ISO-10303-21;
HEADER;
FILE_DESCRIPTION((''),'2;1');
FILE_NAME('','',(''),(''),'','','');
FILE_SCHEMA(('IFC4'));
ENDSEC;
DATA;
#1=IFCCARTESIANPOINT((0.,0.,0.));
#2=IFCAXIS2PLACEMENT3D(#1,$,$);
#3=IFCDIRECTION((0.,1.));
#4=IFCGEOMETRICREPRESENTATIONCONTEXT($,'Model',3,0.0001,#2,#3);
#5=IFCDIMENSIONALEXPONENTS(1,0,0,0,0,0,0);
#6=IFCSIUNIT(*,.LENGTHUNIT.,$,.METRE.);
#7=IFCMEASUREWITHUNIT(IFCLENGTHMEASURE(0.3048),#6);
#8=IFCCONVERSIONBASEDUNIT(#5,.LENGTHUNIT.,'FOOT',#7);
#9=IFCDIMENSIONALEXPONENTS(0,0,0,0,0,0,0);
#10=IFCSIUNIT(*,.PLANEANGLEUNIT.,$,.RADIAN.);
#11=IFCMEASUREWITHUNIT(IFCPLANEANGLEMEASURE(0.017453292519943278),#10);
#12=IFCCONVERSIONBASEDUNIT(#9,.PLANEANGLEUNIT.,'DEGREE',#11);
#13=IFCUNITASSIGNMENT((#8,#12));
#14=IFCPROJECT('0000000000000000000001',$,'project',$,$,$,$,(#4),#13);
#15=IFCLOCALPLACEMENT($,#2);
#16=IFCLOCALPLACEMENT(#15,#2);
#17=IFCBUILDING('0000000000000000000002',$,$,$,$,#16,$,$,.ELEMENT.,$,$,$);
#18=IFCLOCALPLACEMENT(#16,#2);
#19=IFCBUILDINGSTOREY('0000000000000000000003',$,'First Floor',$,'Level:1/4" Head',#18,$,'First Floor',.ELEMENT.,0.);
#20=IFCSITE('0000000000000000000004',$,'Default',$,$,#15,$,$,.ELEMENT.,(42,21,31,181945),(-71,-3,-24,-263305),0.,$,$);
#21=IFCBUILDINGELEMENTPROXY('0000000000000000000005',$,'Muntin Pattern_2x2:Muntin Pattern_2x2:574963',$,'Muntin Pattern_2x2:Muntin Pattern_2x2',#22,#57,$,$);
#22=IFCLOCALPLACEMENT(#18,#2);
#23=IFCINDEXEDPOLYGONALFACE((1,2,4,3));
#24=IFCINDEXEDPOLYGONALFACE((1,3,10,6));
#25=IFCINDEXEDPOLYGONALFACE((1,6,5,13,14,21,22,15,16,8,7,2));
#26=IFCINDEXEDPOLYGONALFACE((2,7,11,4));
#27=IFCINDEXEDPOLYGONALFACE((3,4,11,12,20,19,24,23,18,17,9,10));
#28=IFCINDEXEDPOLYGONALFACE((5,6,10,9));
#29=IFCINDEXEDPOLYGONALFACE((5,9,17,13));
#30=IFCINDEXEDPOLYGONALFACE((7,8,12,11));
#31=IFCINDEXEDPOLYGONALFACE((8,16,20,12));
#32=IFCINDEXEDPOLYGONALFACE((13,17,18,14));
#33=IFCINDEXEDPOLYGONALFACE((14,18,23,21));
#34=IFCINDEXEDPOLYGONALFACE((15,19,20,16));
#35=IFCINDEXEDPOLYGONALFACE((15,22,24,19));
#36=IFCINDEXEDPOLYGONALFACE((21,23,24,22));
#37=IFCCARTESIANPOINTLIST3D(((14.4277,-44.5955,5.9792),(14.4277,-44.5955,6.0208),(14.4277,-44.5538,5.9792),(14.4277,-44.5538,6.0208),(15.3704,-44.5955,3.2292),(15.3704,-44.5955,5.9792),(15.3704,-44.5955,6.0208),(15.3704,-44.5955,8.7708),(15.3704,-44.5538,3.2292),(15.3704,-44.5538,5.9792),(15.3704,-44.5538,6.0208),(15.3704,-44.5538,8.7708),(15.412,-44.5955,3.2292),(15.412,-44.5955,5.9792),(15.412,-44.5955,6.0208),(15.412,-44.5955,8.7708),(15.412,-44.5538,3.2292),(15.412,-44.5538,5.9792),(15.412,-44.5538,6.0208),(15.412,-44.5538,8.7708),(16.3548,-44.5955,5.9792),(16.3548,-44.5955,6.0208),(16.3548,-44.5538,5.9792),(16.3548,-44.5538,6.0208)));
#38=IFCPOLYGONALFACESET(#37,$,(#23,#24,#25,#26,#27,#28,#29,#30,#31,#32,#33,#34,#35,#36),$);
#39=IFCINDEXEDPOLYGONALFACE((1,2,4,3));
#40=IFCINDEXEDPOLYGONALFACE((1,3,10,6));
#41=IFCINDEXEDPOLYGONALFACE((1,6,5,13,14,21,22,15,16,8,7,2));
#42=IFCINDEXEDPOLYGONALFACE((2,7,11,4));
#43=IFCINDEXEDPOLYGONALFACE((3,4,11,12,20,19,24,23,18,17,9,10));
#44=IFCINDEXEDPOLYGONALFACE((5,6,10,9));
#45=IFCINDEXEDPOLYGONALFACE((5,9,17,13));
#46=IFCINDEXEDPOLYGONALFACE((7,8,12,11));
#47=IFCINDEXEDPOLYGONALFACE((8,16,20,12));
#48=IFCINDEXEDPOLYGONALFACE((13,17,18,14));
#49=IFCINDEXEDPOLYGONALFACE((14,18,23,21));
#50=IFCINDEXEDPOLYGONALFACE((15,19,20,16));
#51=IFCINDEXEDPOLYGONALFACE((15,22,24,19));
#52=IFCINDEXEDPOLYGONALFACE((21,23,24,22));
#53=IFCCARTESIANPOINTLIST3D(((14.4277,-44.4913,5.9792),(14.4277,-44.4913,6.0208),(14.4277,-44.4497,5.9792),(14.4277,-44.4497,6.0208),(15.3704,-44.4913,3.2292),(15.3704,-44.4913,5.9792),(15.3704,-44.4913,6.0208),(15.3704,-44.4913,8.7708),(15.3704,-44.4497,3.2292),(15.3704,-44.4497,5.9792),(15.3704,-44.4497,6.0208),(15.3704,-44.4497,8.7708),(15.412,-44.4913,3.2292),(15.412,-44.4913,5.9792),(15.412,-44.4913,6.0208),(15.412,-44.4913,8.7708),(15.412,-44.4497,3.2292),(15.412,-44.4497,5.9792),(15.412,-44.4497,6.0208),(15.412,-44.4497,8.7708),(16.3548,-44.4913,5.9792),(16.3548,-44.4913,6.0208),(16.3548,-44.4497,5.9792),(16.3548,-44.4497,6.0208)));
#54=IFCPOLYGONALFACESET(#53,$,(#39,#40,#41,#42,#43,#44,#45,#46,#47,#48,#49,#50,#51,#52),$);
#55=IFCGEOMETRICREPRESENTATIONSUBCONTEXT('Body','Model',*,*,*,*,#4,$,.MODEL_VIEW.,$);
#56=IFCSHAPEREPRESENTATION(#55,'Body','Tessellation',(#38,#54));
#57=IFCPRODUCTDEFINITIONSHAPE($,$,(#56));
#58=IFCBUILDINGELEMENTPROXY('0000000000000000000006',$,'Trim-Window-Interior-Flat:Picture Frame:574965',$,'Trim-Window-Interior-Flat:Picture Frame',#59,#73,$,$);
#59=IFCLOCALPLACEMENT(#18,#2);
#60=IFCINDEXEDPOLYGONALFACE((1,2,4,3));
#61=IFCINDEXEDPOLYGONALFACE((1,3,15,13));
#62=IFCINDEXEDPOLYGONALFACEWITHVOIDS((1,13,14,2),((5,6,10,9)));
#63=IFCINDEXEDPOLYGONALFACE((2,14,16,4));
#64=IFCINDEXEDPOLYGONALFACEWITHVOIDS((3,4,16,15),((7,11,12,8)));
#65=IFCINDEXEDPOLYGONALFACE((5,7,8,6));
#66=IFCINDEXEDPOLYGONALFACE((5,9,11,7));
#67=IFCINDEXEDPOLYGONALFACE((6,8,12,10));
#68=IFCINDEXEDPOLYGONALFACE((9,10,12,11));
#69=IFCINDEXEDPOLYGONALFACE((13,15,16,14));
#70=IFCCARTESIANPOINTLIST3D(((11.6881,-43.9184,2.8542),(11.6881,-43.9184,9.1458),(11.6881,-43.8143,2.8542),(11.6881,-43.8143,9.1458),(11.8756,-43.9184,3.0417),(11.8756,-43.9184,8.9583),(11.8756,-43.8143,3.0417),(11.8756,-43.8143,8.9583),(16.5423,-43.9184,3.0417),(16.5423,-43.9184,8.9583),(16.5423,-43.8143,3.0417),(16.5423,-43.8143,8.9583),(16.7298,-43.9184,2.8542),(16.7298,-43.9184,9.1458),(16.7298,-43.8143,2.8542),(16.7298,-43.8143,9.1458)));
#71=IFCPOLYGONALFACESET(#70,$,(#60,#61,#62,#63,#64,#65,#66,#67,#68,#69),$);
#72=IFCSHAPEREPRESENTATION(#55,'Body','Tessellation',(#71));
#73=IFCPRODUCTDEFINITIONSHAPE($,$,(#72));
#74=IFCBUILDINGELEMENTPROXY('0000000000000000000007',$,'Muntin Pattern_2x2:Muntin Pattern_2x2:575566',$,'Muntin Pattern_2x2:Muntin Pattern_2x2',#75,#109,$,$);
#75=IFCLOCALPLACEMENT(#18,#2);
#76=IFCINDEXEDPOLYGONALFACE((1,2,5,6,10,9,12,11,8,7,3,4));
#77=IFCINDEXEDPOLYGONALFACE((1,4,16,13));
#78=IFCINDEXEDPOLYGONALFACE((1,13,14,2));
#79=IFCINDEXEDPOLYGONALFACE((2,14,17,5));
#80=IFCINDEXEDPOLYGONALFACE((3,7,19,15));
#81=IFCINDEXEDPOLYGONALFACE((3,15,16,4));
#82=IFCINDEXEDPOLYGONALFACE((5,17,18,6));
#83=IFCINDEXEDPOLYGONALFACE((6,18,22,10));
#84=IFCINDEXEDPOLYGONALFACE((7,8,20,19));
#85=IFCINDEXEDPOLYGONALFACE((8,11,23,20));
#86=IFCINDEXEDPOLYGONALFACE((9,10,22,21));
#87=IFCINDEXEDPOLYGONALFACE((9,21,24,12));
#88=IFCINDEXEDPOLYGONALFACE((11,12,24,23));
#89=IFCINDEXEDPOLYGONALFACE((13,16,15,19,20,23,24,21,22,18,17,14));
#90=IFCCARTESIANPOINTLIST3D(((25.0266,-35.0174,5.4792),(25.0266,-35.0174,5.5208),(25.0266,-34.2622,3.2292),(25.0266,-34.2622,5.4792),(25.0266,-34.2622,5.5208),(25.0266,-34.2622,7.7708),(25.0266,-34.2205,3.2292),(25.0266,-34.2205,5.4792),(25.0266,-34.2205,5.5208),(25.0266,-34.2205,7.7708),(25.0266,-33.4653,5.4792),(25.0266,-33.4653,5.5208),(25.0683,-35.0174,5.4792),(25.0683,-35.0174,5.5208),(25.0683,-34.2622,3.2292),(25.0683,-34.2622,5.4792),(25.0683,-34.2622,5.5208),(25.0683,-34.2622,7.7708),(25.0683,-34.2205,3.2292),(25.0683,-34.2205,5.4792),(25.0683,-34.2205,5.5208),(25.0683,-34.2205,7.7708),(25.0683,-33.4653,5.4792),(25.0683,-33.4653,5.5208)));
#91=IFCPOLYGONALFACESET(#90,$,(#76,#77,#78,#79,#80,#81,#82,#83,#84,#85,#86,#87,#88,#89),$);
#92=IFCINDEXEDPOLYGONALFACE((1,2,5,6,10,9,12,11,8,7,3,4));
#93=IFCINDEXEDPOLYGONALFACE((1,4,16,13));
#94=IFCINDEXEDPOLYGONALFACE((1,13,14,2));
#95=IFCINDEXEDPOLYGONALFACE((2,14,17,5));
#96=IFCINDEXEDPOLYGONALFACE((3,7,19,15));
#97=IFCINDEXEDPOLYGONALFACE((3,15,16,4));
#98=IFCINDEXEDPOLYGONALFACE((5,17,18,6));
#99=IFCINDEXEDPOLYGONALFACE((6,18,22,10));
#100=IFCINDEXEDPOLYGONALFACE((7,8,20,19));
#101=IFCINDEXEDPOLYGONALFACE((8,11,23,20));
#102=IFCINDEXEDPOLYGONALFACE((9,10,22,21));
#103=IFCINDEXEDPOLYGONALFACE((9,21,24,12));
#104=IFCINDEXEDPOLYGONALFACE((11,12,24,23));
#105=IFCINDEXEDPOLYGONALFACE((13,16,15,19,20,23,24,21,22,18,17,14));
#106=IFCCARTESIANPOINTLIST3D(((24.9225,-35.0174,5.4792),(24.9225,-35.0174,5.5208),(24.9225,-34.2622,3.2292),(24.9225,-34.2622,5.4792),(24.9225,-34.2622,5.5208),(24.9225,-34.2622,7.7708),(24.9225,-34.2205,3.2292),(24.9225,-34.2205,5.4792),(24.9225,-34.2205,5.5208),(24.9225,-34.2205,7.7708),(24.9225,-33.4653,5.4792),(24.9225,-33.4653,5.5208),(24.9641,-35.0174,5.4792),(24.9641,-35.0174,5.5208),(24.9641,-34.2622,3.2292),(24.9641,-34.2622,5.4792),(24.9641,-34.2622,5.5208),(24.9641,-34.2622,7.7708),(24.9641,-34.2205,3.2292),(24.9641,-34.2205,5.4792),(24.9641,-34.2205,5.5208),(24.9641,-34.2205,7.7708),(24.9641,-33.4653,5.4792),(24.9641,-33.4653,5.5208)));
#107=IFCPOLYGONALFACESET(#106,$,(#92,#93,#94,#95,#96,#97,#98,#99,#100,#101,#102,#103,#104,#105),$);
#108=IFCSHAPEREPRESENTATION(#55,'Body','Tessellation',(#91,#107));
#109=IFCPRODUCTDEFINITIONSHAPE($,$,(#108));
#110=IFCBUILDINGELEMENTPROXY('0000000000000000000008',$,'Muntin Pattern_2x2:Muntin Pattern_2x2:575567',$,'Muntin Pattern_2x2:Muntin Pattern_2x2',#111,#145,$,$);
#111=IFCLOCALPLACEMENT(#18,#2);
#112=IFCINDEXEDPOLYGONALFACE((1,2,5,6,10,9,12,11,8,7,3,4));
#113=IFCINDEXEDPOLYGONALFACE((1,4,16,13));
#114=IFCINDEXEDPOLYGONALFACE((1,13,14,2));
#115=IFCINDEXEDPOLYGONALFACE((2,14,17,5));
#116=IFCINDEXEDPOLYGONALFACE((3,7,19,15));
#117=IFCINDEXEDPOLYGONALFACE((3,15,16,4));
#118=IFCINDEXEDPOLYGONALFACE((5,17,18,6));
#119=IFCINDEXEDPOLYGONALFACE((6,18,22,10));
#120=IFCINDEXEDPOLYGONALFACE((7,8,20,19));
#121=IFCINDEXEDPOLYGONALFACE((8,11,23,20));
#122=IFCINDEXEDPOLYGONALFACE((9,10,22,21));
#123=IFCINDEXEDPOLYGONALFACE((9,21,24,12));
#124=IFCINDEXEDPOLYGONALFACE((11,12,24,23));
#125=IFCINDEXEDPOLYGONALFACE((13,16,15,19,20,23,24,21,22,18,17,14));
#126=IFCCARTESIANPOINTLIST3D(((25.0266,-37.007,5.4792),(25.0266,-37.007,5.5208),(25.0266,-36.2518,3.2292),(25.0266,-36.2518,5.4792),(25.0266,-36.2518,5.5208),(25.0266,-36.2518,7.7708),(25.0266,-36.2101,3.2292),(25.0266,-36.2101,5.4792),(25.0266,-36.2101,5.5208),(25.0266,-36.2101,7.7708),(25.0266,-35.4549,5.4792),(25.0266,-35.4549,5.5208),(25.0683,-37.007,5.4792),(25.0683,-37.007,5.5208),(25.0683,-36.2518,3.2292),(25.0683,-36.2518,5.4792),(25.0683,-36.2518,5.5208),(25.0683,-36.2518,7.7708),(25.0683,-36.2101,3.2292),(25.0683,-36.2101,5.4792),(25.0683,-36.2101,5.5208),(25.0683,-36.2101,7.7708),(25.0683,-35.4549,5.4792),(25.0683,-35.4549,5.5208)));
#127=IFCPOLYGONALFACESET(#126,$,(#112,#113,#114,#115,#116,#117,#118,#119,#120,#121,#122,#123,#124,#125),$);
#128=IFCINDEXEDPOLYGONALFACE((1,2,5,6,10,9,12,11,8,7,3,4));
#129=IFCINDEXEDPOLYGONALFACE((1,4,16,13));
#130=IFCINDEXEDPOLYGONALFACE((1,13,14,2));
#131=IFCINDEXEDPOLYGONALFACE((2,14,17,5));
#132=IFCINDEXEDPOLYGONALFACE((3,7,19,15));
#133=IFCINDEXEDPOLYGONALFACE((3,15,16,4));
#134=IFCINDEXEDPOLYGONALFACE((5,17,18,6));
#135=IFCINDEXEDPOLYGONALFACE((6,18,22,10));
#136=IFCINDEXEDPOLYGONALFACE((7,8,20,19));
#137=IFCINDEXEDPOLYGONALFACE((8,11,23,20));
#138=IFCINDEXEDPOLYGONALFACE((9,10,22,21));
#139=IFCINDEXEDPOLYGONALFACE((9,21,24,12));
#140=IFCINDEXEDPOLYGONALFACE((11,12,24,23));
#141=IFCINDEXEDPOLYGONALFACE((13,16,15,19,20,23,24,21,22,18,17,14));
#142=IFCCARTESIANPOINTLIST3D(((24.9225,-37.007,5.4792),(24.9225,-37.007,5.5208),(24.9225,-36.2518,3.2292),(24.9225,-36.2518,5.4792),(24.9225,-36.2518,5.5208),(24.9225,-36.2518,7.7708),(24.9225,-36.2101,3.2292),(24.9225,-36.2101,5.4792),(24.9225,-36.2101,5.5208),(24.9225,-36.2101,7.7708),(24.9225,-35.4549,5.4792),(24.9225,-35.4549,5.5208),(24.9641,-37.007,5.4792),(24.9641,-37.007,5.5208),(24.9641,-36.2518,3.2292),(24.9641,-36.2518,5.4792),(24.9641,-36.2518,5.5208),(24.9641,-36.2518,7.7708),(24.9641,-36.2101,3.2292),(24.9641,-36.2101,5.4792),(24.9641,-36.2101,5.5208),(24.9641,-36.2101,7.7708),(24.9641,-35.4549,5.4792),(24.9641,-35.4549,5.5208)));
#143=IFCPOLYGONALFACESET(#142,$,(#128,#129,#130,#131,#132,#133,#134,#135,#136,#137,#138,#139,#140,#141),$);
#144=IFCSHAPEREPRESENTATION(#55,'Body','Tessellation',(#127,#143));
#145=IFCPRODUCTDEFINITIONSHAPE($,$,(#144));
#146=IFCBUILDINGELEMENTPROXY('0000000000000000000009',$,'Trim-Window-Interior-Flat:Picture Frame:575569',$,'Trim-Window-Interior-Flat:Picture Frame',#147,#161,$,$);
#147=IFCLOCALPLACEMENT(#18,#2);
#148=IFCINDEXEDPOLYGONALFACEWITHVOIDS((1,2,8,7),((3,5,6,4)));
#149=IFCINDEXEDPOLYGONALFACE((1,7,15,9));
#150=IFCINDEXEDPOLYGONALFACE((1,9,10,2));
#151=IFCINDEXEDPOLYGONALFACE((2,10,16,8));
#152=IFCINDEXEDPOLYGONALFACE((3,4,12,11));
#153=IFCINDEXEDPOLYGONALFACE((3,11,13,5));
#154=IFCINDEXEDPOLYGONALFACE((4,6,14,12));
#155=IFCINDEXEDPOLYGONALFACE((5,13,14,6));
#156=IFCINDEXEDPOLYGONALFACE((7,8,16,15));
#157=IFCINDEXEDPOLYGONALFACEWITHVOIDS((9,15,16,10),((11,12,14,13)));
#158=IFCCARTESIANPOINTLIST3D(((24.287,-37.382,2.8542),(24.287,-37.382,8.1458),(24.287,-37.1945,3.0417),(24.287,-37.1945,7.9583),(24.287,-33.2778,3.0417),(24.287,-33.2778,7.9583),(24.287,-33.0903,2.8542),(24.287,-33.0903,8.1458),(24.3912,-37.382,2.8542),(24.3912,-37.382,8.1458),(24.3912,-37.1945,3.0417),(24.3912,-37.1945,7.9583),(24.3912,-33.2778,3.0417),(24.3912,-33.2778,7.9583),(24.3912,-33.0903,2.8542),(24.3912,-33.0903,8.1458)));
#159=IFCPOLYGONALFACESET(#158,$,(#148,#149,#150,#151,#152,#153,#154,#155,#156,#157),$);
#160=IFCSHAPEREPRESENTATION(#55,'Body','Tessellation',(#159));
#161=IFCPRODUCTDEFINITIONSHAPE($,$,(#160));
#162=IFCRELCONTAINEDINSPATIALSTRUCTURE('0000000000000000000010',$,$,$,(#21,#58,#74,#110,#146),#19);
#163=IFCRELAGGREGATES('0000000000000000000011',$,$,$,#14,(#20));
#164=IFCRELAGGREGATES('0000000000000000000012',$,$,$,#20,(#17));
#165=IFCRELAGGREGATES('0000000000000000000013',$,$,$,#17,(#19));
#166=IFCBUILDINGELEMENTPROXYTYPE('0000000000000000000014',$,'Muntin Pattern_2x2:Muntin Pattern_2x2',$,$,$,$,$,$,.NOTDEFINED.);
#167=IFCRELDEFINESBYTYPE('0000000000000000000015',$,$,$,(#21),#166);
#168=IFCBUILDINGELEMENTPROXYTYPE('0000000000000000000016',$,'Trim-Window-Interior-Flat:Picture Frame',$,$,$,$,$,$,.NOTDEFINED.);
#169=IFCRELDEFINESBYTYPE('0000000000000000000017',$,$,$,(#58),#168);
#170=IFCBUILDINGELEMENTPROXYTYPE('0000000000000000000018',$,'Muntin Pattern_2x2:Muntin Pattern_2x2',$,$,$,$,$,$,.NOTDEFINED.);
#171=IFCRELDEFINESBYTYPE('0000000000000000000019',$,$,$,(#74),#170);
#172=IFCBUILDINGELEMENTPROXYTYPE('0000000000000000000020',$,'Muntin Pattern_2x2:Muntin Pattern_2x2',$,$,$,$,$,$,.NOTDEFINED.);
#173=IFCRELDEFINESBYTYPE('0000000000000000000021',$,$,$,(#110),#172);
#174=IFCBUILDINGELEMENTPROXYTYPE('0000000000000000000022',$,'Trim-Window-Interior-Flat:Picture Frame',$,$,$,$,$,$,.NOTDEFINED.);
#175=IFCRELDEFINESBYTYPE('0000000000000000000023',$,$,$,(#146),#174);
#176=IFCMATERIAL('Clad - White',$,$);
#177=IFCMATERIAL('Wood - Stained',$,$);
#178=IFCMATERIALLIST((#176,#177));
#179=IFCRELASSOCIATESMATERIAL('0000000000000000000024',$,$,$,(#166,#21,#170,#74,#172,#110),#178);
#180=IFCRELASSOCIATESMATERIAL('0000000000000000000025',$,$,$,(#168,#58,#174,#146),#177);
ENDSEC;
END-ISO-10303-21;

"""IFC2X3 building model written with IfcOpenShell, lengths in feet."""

from ifc_helpers import new_model, entity, si_unit, converted_unit, direction, frame, origin, place, context, subcontext, project, spatial, polyline, outline, extrude, source, transform, mapped, material, material_list, type_object, type_shapes, element, save


model = new_model("IFC2X3")

# Units and contexts
model_context = context("Model", 3, precision=0.0001, world=origin(), true_north=direction((0.0, 1.0)))
body_context = subcontext(model_context, "Body", "Model", "MODEL_VIEW")
ifc_project = project(units=[converted_unit("LENGTHUNIT", "FOOT", entity("IfcLengthMeasure", 0.3048), si_unit("LENGTHUNIT", "METRE"), dimensions=[1, 0, 0, 0, 0, 0, 0]), converted_unit("PLANEANGLEUNIT", "DEGREE", entity("IfcPlaneAngleMeasure", 0.017453292519943278), si_unit("PLANEANGLEUNIT", "RADIAN"), dimensions=[0, 0, 0, 0, 0, 0, 0])], contexts=[model_context])

# Site, building, storey
site_placement = place(None, origin())
site = spatial("IfcSite", under=ifc_project, at=site_placement, Name="Default", CompositionType="ELEMENT", RefLatitude=(42, 21, 31, 181945), RefLongitude=(-71, -3, -24, -263305), RefElevation=0.0)
building_placement = place(site_placement, origin())
building = spatial("IfcBuilding", under=site, at=building_placement, CompositionType="ELEMENT")
storey_placement = place(building_placement, origin())
storey = spatial("IfcBuildingStorey", under=building, at=storey_placement, Name="First Floor", ObjectType="Level:1/4\" Head", LongName="First Floor", CompositionType="ELEMENT", Elevation=0.0)

# Building element proxies
ifc_material_1 = material(Name="Clad - White")
ifc_material_2 = material(Name="Wood - Stained")
ifc_material_list_1 = material_list([ifc_material_1, ifc_material_2])
building_element_proxy_type_1 = type_object("IfcBuildingElementProxyType", Name="Muntin Pattern_2x2:Muntin Pattern_2x2", PredefinedType="NOTDEFINED", material=ifc_material_list_1)
shared_shape_1 = source(origin(), body_context, "Body", "SweptSolid", [
    extrude(outline(polyline([(0.0208, -0.0208), (2.7708, -0.0208), (2.7708, 0.0208), (0.0208, 0.0208), (0.0208, 0.9635), (-0.0208, 0.9635), (-0.0208, 0.0208), (-2.7708, 0.0208), (-2.7708, -0.0208), (-0.0208, -0.0208), (-0.0208, -0.9635), (0.0208, -0.9635), (0.0208, -0.0208)])), frame((0.0, 0.0313, 2.7708), z_axis=(0.0, 1.0, 0.0), x_axis=(0.0, 0.0, 1.0)), (0.0, 0.0, 1.0), 0.0417),
    extrude(outline(polyline([(0.0208, -0.0208), (2.7708, -0.0208), (2.7708, 0.0208), (0.0208, 0.0208), (0.0208, 0.9635), (-0.0208, 0.9635), (-0.0208, 0.0208), (-2.7708, 0.0208), (-2.7708, -0.0208), (-0.0208, -0.0208), (-0.0208, -0.9635), (0.0208, -0.9635), (0.0208, -0.0208)])), frame((0.0, -0.0729, 2.7708), z_axis=(0.0, 1.0, 0.0), x_axis=(0.0, 0.0, 1.0)), (0.0, 0.0, 1.0), 0.0417),
])
type_shapes(building_element_proxy_type_1, [shared_shape_1])
proxy_1_placement = place(storey_placement, frame((15.3912, -44.5226, 3.2292), z_axis=(0.0, 0.0, 1.0), x_axis=(-1.0, 0.0, 0.0)))
element("IfcBuildingElementProxy", 1, at=proxy_1_placement, inside=storey, type_object=building_element_proxy_type_1, material=ifc_material_list_1, Name="Muntin Pattern_2x2:Muntin Pattern_2x2:574963", ObjectType="Muntin Pattern_2x2:Muntin Pattern_2x2", context=body_context, shape_type="MappedRepresentation", body=[
    mapped(shared_shape_1, transform((0.0, 0.0, 0.0), scale=1.0)),
])
building_element_proxy_type_2 = type_object("IfcBuildingElementProxyType", Name="Trim-Window-Interior-Flat:Picture Frame", PredefinedType="NOTDEFINED", material=ifc_material_2)
shared_shape_2 = source(origin(), body_context, "Body", "SweptSolid", [
    extrude(outline(polyline([(-3.1458, -2.5208), (3.1458, -2.5208), (3.1458, 2.5208), (-3.1458, 2.5208), (-3.1458, -2.5208)]), holes=[polyline([(-2.9583, -2.3333), (-2.9583, 2.3333), (2.9583, 2.3333), (2.9583, -2.3333), (-2.9583, -2.3333)])]), frame((0.0, 3.0, 0.0), z_axis=(0.0, 0.0, 1.0), x_axis=(0.0, 1.0, 0.0)), (0.0, 0.0, 1.0), 0.1042),
])
type_shapes(building_element_proxy_type_2, [shared_shape_2])
proxy_2_placement = place(storey_placement, frame((14.2089, -43.9184, 9.0), z_axis=(0.0, 1.0, 0.0), x_axis=(1.0, 0.0, 0.0)))
element("IfcBuildingElementProxy", 2, at=proxy_2_placement, inside=storey, type_object=building_element_proxy_type_2, material=ifc_material_2, Name="Trim-Window-Interior-Flat:Picture Frame:574965", ObjectType="Trim-Window-Interior-Flat:Picture Frame", context=body_context, shape_type="MappedRepresentation", body=[
    mapped(shared_shape_2, transform((0.0, 0.0, 0.0), scale=1.0)),
])
building_element_proxy_type_3 = type_object("IfcBuildingElementProxyType", Name="Muntin Pattern_2x2:Muntin Pattern_2x2", PredefinedType="NOTDEFINED", material=ifc_material_list_1)
shared_shape_3 = source(origin(), body_context, "Body", "SweptSolid", [
    extrude(outline(polyline([(0.0208, -0.0208), (2.2708, -0.0208), (2.2708, 0.0208), (0.0208, 0.0208), (0.0208, 0.776), (-0.0208, 0.776), (-0.0208, 0.0208), (-2.2708, 0.0208), (-2.2708, -0.0208), (-0.0208, -0.0208), (-0.0208, -0.776), (0.0208, -0.776), (0.0208, -0.0208)])), frame((0.0, 0.0313, 2.2708), z_axis=(0.0, 1.0, 0.0), x_axis=(0.0, 0.0, 1.0)), (0.0, 0.0, 1.0), 0.0417),
    extrude(outline(polyline([(0.0208, -0.0208), (2.2708, -0.0208), (2.2708, 0.0208), (0.0208, 0.0208), (0.0208, 0.776), (-0.0208, 0.776), (-0.0208, 0.0208), (-2.2708, 0.0208), (-2.2708, -0.0208), (-0.0208, -0.0208), (-0.0208, -0.776), (0.0208, -0.776), (0.0208, -0.0208)])), frame((0.0, -0.0729, 2.2708), z_axis=(0.0, 1.0, 0.0), x_axis=(0.0, 0.0, 1.0)), (0.0, 0.0, 1.0), 0.0417),
])
type_shapes(building_element_proxy_type_3, [shared_shape_3])
proxy_3_placement = place(storey_placement, frame((24.9954, -34.2413, 3.2292), z_axis=(0.0, 0.0, 1.0), x_axis=(0.0, -1.0, 0.0)))
element("IfcBuildingElementProxy", 3, at=proxy_3_placement, inside=storey, type_object=building_element_proxy_type_3, material=ifc_material_list_1, Name="Muntin Pattern_2x2:Muntin Pattern_2x2:575566", ObjectType="Muntin Pattern_2x2:Muntin Pattern_2x2", context=body_context, shape_type="MappedRepresentation", body=[
    mapped(shared_shape_3, transform((0.0, 0.0, 0.0), scale=1.0)),
])
building_element_proxy_type_4 = type_object("IfcBuildingElementProxyType", Name="Muntin Pattern_2x2:Muntin Pattern_2x2", PredefinedType="NOTDEFINED", material=ifc_material_list_1)
shared_shape_4 = source(origin(), body_context, "Body", "SweptSolid", [
    extrude(outline(polyline([(0.0208, -0.0208), (2.2708, -0.0208), (2.2708, 0.0208), (0.0208, 0.0208), (0.0208, 0.776), (-0.0208, 0.776), (-0.0208, 0.0208), (-2.2708, 0.0208), (-2.2708, -0.0208), (-0.0208, -0.0208), (-0.0208, -0.776), (0.0208, -0.776), (0.0208, -0.0208)])), frame((0.0, -0.0729, 2.2708), z_axis=(0.0, 1.0, 0.0), x_axis=(0.0, 0.0, 1.0)), (0.0, 0.0, 1.0), 0.0417),
    extrude(outline(polyline([(0.0208, -0.0208), (2.2708, -0.0208), (2.2708, 0.0208), (0.0208, 0.0208), (0.0208, 0.776), (-0.0208, 0.776), (-0.0208, 0.0208), (-2.2708, 0.0208), (-2.2708, -0.0208), (-0.0208, -0.0208), (-0.0208, -0.776), (0.0208, -0.776), (0.0208, -0.0208)])), frame((0.0, 0.0313, 2.2708), z_axis=(0.0, 1.0, 0.0), x_axis=(0.0, 0.0, 1.0)), (0.0, 0.0, 1.0), 0.0417),
])
type_shapes(building_element_proxy_type_4, [shared_shape_4])
proxy_4_placement = place(storey_placement, frame((24.9954, -36.2309, 3.2292), z_axis=(0.0, 0.0, 1.0), x_axis=(0.0, 1.0, 0.0)))
element("IfcBuildingElementProxy", 4, at=proxy_4_placement, inside=storey, type_object=building_element_proxy_type_4, material=ifc_material_list_1, Name="Muntin Pattern_2x2:Muntin Pattern_2x2:575567", ObjectType="Muntin Pattern_2x2:Muntin Pattern_2x2", context=body_context, shape_type="MappedRepresentation", body=[
    mapped(shared_shape_4, transform((0.0, 0.0, 0.0), scale=1.0)),
])
building_element_proxy_type_5 = type_object("IfcBuildingElementProxyType", Name="Trim-Window-Interior-Flat:Picture Frame", PredefinedType="NOTDEFINED", material=ifc_material_2)
shared_shape_5 = source(origin(), body_context, "Body", "SweptSolid", [
    extrude(outline(polyline([(-2.1458, -2.6458), (2.1458, -2.6458), (2.1458, 2.6458), (-2.1458, 2.6458), (-2.1458, -2.6458)]), holes=[polyline([(-1.9583, -2.4583), (-1.9583, 2.4583), (1.9583, 2.4583), (1.9583, -2.4583), (-1.9583, -2.4583)])]), frame((0.0, -2.5, 0.0), z_axis=(0.0, 0.0, 1.0), x_axis=(-1.0, 0.0, 0.0)), (0.0, 0.0, 1.0), 0.1042),
])
type_shapes(building_element_proxy_type_5, [shared_shape_5])
proxy_5_placement = place(storey_placement, frame((24.3912, -35.2361, 8.0), z_axis=(-1.0, 0.0, 0.0), x_axis=(0.0, -1.0, 0.0)))
element("IfcBuildingElementProxy", 5, at=proxy_5_placement, inside=storey, type_object=building_element_proxy_type_5, material=ifc_material_2, Name="Trim-Window-Interior-Flat:Picture Frame:575569", ObjectType="Trim-Window-Interior-Flat:Picture Frame", context=body_context, shape_type="MappedRepresentation", body=[
    mapped(shared_shape_5, transform((0.0, 0.0, 0.0), scale=1.0)),
])

save(model, "model.ifc")
